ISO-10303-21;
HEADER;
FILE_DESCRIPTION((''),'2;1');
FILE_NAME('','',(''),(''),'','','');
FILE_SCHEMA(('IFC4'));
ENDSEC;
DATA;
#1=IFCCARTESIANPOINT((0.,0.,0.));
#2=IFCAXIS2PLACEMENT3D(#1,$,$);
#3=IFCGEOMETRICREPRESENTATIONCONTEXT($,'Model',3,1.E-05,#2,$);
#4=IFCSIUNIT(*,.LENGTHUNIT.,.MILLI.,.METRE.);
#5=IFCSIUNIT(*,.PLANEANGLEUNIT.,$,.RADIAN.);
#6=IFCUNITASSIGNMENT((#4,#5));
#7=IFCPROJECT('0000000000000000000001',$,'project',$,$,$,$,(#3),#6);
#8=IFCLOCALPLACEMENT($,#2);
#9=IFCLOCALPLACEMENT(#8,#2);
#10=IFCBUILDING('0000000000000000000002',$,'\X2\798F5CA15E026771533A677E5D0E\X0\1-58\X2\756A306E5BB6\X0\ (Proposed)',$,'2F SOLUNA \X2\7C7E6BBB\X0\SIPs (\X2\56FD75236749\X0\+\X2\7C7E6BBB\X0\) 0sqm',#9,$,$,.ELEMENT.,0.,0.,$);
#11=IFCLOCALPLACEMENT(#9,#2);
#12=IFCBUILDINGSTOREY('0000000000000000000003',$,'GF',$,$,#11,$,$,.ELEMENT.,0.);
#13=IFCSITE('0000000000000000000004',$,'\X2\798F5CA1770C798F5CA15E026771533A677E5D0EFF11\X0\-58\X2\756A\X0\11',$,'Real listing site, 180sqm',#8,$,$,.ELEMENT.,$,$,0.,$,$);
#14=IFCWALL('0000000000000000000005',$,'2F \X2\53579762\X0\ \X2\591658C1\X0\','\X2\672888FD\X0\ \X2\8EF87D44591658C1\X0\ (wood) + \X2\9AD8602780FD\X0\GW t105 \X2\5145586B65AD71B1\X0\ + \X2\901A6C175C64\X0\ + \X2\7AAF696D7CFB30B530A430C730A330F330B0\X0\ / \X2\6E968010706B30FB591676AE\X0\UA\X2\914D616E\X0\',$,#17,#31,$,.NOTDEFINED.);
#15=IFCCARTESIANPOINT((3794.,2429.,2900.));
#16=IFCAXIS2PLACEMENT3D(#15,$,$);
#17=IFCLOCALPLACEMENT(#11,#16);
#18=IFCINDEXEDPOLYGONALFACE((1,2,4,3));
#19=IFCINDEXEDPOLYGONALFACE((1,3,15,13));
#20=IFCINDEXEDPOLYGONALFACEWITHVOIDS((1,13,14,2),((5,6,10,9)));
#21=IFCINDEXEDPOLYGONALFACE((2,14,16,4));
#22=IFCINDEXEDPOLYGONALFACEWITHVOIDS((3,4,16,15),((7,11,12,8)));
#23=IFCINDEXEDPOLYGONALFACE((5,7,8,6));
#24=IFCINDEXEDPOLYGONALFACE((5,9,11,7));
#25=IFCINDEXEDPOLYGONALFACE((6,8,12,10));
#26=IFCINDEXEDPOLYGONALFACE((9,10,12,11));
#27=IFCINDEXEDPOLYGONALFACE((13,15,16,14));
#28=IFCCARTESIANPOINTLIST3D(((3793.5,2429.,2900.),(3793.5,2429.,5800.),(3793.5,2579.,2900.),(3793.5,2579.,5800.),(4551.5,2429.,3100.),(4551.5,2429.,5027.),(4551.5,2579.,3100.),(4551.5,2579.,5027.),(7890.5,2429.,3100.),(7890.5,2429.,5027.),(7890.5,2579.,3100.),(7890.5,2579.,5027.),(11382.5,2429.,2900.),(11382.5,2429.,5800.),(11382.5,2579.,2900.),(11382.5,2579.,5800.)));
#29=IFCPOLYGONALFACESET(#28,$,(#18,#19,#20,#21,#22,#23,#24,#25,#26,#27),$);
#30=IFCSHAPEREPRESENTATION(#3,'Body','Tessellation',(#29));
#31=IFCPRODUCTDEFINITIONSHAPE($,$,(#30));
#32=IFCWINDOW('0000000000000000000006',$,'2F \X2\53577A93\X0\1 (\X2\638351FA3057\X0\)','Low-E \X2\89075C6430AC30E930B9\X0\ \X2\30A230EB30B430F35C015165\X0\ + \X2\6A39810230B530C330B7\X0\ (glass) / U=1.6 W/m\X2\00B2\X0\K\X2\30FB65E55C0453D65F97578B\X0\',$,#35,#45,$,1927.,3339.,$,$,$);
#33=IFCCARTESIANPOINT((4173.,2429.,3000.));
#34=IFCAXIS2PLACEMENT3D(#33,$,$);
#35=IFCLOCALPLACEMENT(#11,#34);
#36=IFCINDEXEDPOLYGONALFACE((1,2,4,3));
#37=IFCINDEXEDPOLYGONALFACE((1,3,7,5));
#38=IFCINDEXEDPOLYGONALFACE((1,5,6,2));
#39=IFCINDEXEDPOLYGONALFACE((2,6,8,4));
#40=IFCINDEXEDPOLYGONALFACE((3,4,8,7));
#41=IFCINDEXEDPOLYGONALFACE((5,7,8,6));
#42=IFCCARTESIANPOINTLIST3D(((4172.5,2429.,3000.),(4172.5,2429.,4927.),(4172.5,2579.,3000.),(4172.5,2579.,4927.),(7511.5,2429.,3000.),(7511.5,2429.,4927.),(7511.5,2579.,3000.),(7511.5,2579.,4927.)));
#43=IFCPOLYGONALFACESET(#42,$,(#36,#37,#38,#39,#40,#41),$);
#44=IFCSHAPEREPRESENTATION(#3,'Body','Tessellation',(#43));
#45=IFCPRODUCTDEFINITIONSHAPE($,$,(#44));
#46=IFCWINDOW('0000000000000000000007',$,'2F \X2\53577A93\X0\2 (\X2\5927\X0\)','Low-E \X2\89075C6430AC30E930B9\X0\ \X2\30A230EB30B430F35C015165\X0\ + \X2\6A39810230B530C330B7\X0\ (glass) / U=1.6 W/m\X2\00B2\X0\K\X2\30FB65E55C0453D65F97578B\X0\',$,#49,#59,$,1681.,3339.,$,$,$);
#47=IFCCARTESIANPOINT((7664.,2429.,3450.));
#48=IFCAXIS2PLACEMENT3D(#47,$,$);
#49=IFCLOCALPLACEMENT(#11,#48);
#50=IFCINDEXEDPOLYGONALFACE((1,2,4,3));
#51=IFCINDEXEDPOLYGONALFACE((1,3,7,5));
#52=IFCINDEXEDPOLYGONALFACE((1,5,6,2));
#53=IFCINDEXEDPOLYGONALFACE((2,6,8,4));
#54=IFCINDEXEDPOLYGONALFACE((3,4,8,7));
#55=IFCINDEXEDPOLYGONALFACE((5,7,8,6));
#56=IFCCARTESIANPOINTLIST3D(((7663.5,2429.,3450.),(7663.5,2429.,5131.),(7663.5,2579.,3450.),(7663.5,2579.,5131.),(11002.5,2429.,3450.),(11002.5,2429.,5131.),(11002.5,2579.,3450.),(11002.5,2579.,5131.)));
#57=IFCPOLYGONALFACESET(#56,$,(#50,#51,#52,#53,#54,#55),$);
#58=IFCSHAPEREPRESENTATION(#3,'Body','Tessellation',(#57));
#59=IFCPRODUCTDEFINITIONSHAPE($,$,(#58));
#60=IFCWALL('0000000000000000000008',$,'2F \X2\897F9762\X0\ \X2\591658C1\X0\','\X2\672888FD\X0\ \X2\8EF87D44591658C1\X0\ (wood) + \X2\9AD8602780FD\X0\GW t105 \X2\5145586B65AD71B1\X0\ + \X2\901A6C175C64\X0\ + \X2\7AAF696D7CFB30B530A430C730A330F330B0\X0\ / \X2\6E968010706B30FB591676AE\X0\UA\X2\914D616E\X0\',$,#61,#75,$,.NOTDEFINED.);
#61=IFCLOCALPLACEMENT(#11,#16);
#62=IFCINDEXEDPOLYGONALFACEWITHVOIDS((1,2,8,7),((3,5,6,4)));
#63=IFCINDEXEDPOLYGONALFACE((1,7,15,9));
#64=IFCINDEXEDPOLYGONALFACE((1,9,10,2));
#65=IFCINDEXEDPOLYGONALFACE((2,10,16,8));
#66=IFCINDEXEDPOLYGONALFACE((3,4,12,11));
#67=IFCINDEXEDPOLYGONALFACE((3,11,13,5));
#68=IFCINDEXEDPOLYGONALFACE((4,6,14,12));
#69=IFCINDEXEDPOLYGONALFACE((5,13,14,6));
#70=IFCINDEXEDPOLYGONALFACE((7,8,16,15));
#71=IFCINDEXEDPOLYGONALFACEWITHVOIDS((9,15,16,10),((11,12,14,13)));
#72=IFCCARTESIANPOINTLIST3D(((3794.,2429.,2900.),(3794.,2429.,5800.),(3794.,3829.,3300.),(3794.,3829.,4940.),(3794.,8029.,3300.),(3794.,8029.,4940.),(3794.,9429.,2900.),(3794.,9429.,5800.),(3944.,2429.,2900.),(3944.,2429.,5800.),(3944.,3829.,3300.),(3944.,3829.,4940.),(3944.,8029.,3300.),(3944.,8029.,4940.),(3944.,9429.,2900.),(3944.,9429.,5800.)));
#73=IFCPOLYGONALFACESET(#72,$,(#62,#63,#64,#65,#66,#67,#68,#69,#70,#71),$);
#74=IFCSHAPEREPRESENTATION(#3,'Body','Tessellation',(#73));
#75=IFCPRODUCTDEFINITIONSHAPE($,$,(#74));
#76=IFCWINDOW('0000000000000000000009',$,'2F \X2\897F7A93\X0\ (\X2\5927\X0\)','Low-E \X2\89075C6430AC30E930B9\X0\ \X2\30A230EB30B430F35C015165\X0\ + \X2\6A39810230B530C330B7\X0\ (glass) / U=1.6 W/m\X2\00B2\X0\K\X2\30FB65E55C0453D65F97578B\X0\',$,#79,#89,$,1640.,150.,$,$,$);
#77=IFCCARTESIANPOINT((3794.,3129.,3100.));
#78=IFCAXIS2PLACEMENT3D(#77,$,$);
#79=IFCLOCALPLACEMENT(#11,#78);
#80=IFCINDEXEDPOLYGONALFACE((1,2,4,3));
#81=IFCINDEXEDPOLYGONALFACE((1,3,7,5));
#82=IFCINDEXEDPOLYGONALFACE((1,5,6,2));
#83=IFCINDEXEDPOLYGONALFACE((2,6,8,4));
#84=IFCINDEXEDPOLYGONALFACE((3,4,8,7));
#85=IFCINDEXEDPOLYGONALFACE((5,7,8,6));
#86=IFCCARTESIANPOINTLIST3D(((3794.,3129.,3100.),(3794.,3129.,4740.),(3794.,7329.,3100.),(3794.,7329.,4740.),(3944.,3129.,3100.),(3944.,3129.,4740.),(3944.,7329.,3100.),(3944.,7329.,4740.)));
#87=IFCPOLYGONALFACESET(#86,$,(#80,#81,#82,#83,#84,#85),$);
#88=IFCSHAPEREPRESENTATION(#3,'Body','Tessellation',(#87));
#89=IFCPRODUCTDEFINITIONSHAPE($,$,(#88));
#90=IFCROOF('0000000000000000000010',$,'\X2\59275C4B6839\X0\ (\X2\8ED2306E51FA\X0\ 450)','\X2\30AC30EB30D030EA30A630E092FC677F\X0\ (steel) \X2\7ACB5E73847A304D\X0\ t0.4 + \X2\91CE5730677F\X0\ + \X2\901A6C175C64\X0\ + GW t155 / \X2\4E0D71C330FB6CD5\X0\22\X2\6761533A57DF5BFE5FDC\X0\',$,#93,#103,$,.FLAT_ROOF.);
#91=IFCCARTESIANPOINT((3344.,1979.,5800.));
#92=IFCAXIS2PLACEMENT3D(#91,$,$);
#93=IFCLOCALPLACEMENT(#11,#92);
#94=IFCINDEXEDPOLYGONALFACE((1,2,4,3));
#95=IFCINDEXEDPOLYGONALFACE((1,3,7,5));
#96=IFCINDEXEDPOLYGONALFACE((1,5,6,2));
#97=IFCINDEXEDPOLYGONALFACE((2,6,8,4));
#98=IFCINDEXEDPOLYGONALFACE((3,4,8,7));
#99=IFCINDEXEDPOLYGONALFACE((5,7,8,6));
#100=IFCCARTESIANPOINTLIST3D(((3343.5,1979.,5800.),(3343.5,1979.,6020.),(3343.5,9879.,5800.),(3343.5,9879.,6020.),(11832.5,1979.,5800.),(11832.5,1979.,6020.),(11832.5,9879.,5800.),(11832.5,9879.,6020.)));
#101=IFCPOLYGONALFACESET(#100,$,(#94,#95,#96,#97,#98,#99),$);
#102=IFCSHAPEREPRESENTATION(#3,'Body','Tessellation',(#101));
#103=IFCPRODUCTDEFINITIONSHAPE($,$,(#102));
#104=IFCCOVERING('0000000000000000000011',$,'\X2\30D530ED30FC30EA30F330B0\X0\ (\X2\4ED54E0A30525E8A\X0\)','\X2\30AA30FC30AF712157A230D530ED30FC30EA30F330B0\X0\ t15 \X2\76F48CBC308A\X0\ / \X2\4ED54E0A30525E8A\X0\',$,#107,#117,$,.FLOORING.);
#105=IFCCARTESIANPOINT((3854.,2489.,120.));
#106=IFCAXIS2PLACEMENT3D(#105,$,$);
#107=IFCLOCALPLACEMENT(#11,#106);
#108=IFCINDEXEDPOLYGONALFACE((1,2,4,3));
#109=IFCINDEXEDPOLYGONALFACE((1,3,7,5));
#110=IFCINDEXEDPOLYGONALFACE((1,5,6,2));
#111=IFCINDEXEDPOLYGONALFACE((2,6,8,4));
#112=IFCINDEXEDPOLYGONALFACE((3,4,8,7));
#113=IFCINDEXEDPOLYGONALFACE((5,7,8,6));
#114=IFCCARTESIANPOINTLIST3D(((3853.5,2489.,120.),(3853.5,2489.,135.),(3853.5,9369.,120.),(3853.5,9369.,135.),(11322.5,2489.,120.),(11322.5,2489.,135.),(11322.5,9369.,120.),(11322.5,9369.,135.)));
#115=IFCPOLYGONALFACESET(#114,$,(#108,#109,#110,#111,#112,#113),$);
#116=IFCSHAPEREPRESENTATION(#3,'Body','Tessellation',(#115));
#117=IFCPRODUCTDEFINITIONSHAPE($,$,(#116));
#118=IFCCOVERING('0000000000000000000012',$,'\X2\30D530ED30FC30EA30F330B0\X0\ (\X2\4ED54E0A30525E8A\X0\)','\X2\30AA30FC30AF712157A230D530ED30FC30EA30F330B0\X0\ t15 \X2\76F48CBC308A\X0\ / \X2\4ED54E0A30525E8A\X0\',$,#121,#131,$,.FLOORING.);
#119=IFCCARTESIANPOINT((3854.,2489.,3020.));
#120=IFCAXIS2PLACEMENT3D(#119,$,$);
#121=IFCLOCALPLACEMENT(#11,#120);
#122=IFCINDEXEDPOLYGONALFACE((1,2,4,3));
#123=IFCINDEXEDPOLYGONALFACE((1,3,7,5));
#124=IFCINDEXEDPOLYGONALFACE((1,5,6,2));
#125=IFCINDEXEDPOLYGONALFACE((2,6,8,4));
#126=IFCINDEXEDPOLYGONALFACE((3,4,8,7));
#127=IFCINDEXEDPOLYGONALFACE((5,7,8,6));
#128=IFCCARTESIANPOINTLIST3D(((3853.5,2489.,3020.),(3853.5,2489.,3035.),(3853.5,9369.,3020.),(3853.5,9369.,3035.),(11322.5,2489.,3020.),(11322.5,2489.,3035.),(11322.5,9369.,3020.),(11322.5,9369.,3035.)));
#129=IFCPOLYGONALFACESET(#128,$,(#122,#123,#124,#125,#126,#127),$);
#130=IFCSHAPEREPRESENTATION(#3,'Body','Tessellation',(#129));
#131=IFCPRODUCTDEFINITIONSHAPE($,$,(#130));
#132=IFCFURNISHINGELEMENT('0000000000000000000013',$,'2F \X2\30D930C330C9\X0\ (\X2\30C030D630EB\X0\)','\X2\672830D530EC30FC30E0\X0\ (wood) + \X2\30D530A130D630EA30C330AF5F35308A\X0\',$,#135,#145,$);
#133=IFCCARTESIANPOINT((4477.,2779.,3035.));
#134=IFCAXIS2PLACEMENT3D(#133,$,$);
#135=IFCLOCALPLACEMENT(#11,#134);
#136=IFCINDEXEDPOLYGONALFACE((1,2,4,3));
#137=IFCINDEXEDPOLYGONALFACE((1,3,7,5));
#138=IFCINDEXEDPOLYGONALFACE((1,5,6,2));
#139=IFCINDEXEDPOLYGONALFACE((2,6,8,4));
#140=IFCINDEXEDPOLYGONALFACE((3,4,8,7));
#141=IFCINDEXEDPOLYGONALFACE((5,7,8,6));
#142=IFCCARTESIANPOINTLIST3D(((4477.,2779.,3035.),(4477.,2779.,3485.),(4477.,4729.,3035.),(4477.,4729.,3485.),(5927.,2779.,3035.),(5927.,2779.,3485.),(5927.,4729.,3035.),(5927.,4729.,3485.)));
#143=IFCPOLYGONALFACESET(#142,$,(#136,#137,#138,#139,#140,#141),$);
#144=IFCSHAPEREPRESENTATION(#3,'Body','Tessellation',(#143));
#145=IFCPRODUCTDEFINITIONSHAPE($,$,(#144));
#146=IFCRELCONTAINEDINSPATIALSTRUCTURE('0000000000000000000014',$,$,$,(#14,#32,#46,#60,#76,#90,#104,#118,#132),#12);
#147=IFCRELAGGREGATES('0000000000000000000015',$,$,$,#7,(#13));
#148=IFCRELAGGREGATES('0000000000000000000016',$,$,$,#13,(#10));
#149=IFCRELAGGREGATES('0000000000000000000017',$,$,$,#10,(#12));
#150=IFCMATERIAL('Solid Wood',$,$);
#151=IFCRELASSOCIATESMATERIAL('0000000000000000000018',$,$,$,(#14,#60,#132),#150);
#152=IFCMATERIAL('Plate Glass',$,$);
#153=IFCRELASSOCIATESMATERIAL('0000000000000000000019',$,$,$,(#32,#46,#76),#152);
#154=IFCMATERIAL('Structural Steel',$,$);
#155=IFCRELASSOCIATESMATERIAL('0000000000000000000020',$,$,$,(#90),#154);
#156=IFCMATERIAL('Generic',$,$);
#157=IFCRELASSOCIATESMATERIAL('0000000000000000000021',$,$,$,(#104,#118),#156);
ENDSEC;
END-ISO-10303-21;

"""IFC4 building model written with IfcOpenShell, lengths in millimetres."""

from ifc_helpers import new_model, si_unit, frame, frame_2d, origin, place, context, project, spatial, rectangle, extrude, material, element, fill, save


model = new_model("IFC4")

# Units and contexts
model_context = context("Model", 3, precision=1e-05, world=origin())
ifc_project = project(units=[si_unit("LENGTHUNIT", "METRE", prefix="MILLI"), si_unit("PLANEANGLEUNIT", "RADIAN")], contexts=[model_context])

# Site, building, storey
site_placement = place(None, origin())
site = spatial("IfcSite", under=ifc_project, at=site_placement, Name="福岡県福岡市東区松崎１-58番11", ObjectType="Real listing site, 180sqm", CompositionType="ELEMENT", RefElevation=0.0)
building_placement = place(site_placement, origin())
building = spatial("IfcBuilding", under=site, at=building_placement, Name="福岡市東区松崎1-58番の家 (Proposed)", ObjectType="2F SOLUNA 籾殻SIPs (国産杉+籾殻) 0sqm", CompositionType="ELEMENT", ElevationOfRefHeight=0.0, ElevationOfTerrain=0.0)
storey_placement = place(building_placement, origin())
storey = spatial("IfcBuildingStorey", under=building, at=storey_placement, Name="GF", CompositionType="ELEMENT", Elevation=0.0)

# Shared definitions
ifc_material_1 = material(Name="Solid Wood")

# Shared definitions
ifc_material_2 = material(Name="Plate Glass")

# Wall, openings, windows
wall_1_placement = place(storey_placement, frame((3794.0, 2429.0, 2900.0)))
wall_1 = element("IfcWall", 1, at=wall_1_placement, inside=storey, material=ifc_material_1, Name="2F 南面 外壁", Description="木製 軸組外壁 (wood) + 高性能GW t105 充填断熱 + 通気層 + 窯業系サイディング / 準耐火・外皮UA配慮", PredefinedType="NOTDEFINED", context=model_context, shape_type="SweptSolid", body=[
    extrude(rectangle(XDim=7589.0, YDim=150.0, at=frame_2d((3794.0, 75.0))), frame((3794.0, 2429.0, 2900.0)), (0.0, 0.0, 1.0), 2900.0),
])
opening_1_placement = place(storey_placement, frame((4173.0, 2429.0, 3000.0)))
opening_1 = element("IfcOpeningElement", 2, at=opening_1_placement, cuts=wall_1, PredefinedType="NOTDEFINED", context=model_context, shape_type="SweptSolid", body=[
    extrude(rectangle(XDim=3339.0, YDim=150.0, at=frame_2d((1669.0, 75.0))), frame((4173.0, 2429.0, 3000.0)), (0.0, 0.0, 1.0), 1927.0),
])
opening_2_placement = place(storey_placement, frame((7664.0, 2429.0, 3450.0)))
opening_2 = element("IfcOpeningElement", 3, at=opening_2_placement, cuts=wall_1, PredefinedType="NOTDEFINED", context=model_context, shape_type="SweptSolid", body=[
    extrude(rectangle(XDim=3339.0, YDim=150.0, at=frame_2d((1669.0, 75.0))), frame((7664.0, 2429.0, 3450.0)), (0.0, 0.0, 1.0), 1681.0),
])
window_1_placement = place(storey_placement, frame((4173.0, 2429.0, 3000.0)))
window_1 = element("IfcWindow", 4, at=window_1_placement, inside=storey, material=ifc_material_2, Name="2F 南窓1 (掃出し)", Description="Low-E 複層ガラス アルゴン封入 + 樹脂サッシ (glass) / U=1.6 W/m²K・日射取得型", OverallHeight=1927.0, OverallWidth=3339.0, context=model_context, shape_type="SweptSolid", body=[
    extrude(rectangle(XDim=3339.0, YDim=150.0, at=frame_2d((1669.0, 75.0))), frame((4173.0, 2429.0, 3000.0)), (0.0, 0.0, 1.0), 1927.0),
])
fill(opening_1, window_1)
window_2_placement = place(storey_placement, frame((7664.0, 2429.0, 3450.0)))
window_2 = element("IfcWindow", 5, at=window_2_placement, inside=storey, material=ifc_material_2, Name="2F 南窓2 (大)", Description="Low-E 複層ガラス アルゴン封入 + 樹脂サッシ (glass) / U=1.6 W/m²K・日射取得型", OverallHeight=1681.0, OverallWidth=3339.0, context=model_context, shape_type="SweptSolid", body=[
    extrude(rectangle(XDim=3339.0, YDim=150.0, at=frame_2d((1669.0, 75.0))), frame((7664.0, 2429.0, 3450.0)), (0.0, 0.0, 1.0), 1681.0),
])
fill(opening_2, window_2)

# Wall, opening, window
wall_2_placement = place(storey_placement, frame((3794.0, 2429.0, 2900.0)))
wall_2 = element("IfcWall", 6, at=wall_2_placement, inside=storey, material=ifc_material_1, Name="2F 西面 外壁", Description="木製 軸組外壁 (wood) + 高性能GW t105 充填断熱 + 通気層 + 窯業系サイディング / 準耐火・外皮UA配慮", PredefinedType="NOTDEFINED", context=model_context, shape_type="SweptSolid", body=[
    extrude(rectangle(XDim=150.0, YDim=7000.0, at=frame_2d((75.0, 3500.0))), frame((3794.0, 2429.0, 2900.0)), (0.0, 0.0, 1.0), 2900.0),
])
opening_3_placement = place(storey_placement, frame((3794.0, 3129.0, 3100.0)))
opening_3 = element("IfcOpeningElement", 7, at=opening_3_placement, cuts=wall_2, PredefinedType="NOTDEFINED", context=model_context, shape_type="SweptSolid", body=[
    extrude(rectangle(XDim=150.0, YDim=4200.0, at=frame_2d((75.0, 2100.0))), frame((3794.0, 3129.0, 3100.0)), (0.0, 0.0, 1.0), 1640.0),
])
window_3_placement = place(storey_placement, frame((3794.0, 3129.0, 3100.0)))
window_3 = element("IfcWindow", 8, at=window_3_placement, inside=storey, material=ifc_material_2, Name="2F 西窓 (大)", Description="Low-E 複層ガラス アルゴン封入 + 樹脂サッシ (glass) / U=1.6 W/m²K・日射取得型", OverallHeight=1640.0, OverallWidth=150.0, context=model_context, shape_type="SweptSolid", body=[
    extrude(rectangle(XDim=150.0, YDim=4200.0, at=frame_2d((75.0, 2100.0))), frame((3794.0, 3129.0, 3100.0)), (0.0, 0.0, 1.0), 1640.0),
])
fill(opening_3, window_3)

# Roof
ifc_material_3 = material(Name="Structural Steel")
roof_placement = place(storey_placement, frame((3344.0, 1979.0, 5800.0)))
element("IfcRoof", 9, at=roof_placement, inside=storey, material=ifc_material_3, Name="大屋根 (軒の出 450)", Description="ガルバリウム鋼板 (steel) 立平葺き t0.4 + 野地板 + 通気層 + GW t155 / 不燃・法22条区域対応", PredefinedType="FLAT_ROOF", context=model_context, shape_type="SweptSolid", body=[
    extrude(rectangle(XDim=8489.0, YDim=7900.0, at=frame_2d((4244.0, 3950.0))), frame((3344.0, 1979.0, 5800.0)), (0.0, 0.0, 1.0), 220.0),
])

# Coverings
ifc_material_4 = material(Name="Generic")
covering_1_placement = place(storey_placement, frame((3854.0, 2489.0, 120.0)))
element("IfcCovering", 10, at=covering_1_placement, inside=storey, material=ifc_material_4, Name="フローリング (仕上げ床)", Description="オーク無垢フローリング t15 直貼り / 仕上げ床", PredefinedType="FLOORING", context=model_context, shape_type="SweptSolid", body=[
    extrude(rectangle(XDim=7469.0, YDim=6880.0, at=frame_2d((3734.0, 3440.0))), frame((3854.0, 2489.0, 120.0)), (0.0, 0.0, 1.0), 15.0),
])
covering_2_placement = place(storey_placement, frame((3854.0, 2489.0, 3020.0)))
element("IfcCovering", 11, at=covering_2_placement, inside=storey, material=ifc_material_4, Name="フローリング (仕上げ床)", Description="オーク無垢フローリング t15 直貼り / 仕上げ床", PredefinedType="FLOORING", context=model_context, shape_type="SweptSolid", body=[
    extrude(rectangle(XDim=7469.0, YDim=6880.0, at=frame_2d((3734.0, 3440.0))), frame((3854.0, 2489.0, 3020.0)), (0.0, 0.0, 1.0), 15.0),
])

# Furnishing element
furnishing_placement = place(storey_placement, frame((4477.0, 2779.0, 3035.0)))
element("IfcFurnishingElement", 12, at=furnishing_placement, inside=storey, material=ifc_material_1, Name="2F ベッド (ダブル)", Description="木フレーム (wood) + ファブリック張り", context=model_context, shape_type="SweptSolid", body=[
    extrude(rectangle(XDim=1450.0, YDim=1950.0, at=frame_2d((725.0, 975.0))), frame((4477.0, 2779.0, 3035.0)), (0.0, 0.0, 1.0), 450.0),
])

save(model, "model.ifc")
